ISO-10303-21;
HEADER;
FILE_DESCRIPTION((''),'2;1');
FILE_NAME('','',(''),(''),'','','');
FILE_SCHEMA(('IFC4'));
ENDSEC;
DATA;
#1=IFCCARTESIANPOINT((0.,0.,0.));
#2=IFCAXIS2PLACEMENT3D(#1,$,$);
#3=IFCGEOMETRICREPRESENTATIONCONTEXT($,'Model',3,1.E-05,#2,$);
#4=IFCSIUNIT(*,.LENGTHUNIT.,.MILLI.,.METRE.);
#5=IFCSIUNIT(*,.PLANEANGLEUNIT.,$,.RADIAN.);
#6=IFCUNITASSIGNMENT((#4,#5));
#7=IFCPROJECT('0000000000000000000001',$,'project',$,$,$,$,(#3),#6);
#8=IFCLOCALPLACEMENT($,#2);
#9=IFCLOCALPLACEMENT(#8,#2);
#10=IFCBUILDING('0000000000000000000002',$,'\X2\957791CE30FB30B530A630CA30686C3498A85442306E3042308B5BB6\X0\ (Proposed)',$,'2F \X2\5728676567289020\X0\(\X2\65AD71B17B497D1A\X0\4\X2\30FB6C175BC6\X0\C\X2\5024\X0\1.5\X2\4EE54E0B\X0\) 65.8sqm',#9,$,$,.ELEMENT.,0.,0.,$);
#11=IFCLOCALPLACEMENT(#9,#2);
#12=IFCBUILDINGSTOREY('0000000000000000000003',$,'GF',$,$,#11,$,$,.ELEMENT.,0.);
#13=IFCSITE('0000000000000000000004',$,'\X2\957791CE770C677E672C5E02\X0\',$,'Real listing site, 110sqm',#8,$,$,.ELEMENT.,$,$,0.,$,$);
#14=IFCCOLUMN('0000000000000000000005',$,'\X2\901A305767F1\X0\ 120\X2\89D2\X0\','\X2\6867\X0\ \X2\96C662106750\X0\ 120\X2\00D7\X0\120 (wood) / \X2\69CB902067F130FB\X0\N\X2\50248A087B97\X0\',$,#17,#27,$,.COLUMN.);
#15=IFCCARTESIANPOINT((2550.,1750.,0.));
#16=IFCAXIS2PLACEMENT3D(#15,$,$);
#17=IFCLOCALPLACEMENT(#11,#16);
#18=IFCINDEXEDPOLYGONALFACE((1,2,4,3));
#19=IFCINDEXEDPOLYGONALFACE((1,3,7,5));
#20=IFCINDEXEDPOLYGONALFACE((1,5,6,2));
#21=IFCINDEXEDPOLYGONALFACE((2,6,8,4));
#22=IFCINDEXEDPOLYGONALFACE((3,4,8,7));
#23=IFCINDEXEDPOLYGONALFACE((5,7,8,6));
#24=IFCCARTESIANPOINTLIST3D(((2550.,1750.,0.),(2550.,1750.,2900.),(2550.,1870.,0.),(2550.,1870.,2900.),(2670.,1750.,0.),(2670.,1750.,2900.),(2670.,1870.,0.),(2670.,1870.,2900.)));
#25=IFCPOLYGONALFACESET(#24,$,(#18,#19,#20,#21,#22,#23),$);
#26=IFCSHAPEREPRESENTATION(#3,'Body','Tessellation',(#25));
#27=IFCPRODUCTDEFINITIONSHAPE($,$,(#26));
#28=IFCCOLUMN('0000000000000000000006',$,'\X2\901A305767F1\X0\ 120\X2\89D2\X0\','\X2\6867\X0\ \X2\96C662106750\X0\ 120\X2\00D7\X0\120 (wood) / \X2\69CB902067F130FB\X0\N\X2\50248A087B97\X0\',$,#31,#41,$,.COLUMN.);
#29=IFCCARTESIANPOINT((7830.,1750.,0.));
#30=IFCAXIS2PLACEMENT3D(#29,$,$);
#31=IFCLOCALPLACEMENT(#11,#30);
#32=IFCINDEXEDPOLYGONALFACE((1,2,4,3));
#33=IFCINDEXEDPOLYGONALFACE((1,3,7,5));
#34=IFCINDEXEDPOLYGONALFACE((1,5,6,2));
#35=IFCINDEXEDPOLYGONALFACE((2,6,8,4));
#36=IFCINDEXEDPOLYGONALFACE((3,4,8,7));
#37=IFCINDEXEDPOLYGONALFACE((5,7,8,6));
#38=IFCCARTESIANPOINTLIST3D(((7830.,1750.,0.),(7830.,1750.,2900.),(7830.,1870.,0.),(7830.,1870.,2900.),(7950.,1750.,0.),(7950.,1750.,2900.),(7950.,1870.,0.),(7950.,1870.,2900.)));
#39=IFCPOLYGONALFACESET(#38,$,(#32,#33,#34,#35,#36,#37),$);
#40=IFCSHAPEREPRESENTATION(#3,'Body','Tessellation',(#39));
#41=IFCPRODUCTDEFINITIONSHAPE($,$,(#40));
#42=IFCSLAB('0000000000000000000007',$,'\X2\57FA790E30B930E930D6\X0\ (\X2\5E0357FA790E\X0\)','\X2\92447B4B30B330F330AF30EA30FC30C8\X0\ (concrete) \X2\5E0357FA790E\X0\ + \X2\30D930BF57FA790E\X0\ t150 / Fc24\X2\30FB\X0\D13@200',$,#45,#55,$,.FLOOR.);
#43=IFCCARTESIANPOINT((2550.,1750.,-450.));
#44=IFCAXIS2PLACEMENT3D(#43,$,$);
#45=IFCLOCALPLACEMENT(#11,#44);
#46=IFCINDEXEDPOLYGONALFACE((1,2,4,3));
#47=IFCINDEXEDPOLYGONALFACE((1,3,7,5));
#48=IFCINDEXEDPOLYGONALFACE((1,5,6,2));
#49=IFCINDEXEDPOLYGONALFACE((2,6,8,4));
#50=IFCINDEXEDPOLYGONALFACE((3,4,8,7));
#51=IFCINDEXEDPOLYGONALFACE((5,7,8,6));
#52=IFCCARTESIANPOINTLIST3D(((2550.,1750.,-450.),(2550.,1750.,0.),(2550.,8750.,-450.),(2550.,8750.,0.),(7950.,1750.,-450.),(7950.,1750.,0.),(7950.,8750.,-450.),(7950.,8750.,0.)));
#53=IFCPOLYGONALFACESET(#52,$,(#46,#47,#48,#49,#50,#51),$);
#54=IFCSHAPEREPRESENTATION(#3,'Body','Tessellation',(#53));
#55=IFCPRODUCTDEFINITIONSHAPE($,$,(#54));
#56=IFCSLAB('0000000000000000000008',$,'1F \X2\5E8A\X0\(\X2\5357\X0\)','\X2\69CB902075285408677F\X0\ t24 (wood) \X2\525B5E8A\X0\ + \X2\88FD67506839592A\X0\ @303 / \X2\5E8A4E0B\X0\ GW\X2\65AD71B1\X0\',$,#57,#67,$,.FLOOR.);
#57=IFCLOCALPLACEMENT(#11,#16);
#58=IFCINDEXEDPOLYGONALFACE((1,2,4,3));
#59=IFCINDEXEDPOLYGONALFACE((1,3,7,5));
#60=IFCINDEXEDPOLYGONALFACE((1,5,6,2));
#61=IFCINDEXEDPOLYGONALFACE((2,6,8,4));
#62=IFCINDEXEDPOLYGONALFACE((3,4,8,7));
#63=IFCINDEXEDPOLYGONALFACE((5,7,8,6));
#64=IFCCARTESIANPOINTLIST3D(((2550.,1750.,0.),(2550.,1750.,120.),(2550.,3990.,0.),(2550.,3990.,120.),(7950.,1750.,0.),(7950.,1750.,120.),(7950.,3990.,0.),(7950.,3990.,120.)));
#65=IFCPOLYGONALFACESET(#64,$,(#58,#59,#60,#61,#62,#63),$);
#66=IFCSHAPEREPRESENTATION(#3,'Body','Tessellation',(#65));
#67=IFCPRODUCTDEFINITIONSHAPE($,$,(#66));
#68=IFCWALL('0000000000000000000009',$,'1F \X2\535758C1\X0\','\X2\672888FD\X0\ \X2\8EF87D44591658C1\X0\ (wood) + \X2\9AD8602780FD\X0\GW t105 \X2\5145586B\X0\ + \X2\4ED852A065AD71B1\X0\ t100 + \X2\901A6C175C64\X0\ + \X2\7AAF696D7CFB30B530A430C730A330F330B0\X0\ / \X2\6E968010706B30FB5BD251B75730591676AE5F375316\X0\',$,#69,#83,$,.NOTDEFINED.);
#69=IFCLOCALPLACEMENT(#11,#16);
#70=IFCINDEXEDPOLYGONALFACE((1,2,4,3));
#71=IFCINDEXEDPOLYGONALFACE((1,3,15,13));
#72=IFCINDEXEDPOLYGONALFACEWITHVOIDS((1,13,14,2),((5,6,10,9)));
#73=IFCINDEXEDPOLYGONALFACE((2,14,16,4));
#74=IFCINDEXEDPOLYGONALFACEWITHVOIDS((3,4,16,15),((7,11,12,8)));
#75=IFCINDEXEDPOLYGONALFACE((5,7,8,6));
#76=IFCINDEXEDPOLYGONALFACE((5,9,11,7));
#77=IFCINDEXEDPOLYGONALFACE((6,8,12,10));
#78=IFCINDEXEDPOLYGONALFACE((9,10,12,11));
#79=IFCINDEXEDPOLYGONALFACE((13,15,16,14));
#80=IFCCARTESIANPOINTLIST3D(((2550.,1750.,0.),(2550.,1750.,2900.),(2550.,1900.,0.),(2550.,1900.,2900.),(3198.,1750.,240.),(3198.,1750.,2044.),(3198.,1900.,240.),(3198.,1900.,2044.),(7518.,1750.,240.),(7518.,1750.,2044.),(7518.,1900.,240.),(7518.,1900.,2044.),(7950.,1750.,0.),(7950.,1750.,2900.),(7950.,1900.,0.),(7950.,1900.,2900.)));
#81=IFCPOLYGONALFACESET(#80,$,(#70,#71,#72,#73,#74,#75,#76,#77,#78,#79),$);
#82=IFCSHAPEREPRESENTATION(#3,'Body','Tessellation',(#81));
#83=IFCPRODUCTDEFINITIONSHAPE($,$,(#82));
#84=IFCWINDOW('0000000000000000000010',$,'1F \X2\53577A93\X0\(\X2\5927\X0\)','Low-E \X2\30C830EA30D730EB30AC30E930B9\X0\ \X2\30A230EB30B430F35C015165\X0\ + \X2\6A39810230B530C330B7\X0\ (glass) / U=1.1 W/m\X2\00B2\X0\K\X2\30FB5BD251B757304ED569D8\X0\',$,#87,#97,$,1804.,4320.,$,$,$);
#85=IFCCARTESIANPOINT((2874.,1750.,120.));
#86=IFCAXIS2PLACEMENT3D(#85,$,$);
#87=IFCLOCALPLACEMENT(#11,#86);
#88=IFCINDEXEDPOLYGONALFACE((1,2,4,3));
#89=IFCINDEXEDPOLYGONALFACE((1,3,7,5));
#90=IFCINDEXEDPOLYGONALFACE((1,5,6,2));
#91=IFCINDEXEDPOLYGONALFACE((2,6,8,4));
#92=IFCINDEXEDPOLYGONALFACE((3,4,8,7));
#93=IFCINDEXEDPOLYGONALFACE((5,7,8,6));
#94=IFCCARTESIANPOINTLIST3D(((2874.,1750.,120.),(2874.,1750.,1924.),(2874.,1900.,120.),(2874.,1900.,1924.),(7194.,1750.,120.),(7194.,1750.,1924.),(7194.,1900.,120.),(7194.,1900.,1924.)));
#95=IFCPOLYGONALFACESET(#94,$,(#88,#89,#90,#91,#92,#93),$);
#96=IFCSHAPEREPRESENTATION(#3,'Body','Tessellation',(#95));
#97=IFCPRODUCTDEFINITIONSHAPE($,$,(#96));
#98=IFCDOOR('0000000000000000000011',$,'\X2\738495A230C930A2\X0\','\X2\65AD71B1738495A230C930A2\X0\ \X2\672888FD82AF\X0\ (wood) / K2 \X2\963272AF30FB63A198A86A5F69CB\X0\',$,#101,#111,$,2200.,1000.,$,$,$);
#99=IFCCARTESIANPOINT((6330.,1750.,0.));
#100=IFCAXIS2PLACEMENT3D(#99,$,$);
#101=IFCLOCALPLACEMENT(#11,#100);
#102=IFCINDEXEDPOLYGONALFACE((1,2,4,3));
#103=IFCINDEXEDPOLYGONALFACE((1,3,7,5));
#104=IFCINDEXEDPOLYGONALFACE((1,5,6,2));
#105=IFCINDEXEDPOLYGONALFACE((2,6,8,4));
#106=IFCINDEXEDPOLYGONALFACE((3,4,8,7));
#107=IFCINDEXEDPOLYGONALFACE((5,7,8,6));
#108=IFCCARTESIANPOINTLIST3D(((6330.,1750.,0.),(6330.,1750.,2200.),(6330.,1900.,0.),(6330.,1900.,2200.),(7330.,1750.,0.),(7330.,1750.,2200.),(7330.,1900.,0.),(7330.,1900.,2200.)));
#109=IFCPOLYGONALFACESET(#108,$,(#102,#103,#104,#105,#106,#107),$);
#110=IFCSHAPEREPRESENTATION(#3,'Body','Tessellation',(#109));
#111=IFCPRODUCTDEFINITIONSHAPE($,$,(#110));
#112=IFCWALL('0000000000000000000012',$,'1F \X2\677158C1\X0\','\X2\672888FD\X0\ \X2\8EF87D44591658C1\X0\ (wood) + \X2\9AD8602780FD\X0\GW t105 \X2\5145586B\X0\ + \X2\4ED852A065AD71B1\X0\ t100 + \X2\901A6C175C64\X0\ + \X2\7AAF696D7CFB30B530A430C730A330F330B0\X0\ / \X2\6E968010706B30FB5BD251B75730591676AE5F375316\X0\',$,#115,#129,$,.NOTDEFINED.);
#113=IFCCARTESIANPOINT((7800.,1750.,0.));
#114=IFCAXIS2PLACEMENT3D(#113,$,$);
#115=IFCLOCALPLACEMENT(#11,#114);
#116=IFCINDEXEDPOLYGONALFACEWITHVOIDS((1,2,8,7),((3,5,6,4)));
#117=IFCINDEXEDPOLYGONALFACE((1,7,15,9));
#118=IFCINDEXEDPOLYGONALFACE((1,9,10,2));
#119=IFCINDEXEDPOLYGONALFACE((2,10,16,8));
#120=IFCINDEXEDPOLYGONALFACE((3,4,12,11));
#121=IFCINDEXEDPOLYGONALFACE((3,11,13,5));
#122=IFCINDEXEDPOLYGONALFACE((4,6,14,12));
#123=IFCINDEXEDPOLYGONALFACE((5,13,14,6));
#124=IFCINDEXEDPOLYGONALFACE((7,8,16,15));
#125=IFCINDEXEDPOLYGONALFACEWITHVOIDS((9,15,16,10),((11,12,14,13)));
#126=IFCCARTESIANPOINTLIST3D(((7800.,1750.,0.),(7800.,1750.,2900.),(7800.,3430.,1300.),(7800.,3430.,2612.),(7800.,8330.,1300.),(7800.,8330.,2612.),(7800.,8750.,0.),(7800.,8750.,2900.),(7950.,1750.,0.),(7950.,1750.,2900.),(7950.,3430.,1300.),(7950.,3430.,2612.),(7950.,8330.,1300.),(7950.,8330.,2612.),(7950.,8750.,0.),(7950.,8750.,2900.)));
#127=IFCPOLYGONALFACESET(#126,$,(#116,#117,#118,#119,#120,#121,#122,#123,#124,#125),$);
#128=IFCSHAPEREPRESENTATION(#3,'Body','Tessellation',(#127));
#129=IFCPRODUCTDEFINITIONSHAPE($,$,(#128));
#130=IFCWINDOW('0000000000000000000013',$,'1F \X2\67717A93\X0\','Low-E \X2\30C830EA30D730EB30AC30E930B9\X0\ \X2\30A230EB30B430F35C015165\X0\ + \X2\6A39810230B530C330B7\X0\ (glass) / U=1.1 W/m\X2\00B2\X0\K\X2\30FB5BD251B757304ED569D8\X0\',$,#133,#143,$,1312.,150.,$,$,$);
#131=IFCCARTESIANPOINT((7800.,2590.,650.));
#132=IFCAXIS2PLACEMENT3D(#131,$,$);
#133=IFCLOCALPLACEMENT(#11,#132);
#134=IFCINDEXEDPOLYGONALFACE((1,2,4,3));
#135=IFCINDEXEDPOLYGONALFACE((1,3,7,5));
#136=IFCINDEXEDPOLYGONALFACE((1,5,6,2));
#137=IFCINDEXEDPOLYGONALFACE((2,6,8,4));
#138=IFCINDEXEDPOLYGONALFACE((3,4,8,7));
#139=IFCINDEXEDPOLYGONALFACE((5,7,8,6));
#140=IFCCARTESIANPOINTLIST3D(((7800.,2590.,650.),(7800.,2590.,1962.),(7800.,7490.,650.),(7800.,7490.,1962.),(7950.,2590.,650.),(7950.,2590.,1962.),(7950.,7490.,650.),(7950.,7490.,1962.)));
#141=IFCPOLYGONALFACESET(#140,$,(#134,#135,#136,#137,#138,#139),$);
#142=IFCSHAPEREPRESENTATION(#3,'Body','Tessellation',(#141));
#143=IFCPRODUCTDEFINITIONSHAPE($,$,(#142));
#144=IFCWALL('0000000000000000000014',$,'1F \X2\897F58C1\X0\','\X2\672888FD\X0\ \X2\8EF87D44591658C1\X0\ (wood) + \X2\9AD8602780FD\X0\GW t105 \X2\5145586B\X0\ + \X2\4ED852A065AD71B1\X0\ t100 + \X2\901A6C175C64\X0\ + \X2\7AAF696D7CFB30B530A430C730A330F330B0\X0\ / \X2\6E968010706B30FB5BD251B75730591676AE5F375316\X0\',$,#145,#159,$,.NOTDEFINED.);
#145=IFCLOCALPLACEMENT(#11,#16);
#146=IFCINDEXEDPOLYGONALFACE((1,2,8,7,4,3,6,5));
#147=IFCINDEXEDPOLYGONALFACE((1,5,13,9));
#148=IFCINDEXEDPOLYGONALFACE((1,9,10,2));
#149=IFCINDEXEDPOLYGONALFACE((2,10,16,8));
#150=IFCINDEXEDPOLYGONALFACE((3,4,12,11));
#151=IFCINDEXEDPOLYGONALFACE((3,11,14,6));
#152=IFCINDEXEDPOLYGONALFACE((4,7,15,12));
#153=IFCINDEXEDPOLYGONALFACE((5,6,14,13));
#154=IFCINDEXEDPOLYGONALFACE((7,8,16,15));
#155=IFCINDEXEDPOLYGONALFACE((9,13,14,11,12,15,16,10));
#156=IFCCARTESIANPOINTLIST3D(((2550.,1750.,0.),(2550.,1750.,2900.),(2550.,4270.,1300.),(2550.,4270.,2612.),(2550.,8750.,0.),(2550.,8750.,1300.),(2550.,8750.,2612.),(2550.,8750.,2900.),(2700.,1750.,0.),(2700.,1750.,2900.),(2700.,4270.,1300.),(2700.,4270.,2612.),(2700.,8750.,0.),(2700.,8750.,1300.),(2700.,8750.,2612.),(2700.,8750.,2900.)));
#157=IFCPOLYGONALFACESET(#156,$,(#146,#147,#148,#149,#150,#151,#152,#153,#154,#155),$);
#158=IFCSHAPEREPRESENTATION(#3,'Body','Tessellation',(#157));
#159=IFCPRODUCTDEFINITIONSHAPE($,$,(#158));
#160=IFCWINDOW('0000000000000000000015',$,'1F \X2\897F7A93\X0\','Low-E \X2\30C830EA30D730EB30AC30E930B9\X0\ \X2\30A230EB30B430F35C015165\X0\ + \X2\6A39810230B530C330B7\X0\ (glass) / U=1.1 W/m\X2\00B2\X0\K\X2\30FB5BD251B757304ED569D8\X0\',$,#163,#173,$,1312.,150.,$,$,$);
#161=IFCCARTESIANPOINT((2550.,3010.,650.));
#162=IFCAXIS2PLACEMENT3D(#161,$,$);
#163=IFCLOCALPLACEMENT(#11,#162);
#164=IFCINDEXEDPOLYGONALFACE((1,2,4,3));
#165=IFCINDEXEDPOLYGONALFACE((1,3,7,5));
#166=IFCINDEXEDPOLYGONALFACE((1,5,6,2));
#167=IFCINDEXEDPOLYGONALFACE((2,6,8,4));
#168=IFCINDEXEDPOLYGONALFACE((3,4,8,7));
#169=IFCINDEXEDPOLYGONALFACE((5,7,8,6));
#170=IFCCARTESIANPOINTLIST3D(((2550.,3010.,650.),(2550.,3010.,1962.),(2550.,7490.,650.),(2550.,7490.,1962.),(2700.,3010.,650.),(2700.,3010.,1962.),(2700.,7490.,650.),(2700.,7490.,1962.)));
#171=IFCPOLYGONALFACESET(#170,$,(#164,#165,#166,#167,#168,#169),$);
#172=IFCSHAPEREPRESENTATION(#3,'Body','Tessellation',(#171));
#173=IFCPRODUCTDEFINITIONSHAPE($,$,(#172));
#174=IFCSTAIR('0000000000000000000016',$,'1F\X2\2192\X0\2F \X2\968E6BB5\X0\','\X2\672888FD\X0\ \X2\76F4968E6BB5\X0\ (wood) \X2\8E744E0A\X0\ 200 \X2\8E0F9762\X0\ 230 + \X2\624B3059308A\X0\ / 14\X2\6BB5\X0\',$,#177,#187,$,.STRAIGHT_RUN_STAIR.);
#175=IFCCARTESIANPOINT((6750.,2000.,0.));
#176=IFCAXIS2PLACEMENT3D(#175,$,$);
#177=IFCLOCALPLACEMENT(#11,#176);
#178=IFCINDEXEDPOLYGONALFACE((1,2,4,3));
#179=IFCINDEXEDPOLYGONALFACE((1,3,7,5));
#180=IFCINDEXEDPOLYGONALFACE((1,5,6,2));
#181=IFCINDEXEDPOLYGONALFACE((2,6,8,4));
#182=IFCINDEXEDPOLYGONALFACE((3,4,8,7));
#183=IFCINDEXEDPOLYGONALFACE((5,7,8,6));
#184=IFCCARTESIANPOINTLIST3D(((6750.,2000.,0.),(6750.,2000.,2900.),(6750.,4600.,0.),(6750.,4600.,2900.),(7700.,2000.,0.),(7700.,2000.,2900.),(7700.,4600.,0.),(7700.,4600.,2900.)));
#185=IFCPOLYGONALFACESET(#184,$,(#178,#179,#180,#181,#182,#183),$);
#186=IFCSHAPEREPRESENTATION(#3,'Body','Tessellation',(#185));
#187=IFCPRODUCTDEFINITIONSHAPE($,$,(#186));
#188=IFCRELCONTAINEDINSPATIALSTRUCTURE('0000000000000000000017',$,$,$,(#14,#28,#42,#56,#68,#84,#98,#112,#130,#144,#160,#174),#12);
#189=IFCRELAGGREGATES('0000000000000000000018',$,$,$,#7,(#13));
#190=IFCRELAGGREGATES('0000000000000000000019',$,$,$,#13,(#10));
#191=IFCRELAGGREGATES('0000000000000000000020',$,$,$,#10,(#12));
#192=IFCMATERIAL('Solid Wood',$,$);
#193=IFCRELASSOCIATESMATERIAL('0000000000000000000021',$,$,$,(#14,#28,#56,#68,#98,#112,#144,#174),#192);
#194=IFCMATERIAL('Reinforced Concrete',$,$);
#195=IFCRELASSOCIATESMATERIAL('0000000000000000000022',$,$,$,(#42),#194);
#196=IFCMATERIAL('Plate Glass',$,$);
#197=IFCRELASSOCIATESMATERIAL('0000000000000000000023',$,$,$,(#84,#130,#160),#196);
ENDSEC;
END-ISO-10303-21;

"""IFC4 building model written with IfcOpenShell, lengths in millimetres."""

from ifc_helpers import new_model, si_unit, frame, frame_2d, origin, place, context, project, spatial, rectangle, extrude, material, element, fill, save


model = new_model("IFC4")

# Units and contexts
model_context = context("Model", 3, precision=1e-05, world=origin())
ifc_project = project(units=[si_unit("LENGTHUNIT", "METRE", prefix="MILLI"), si_unit("PLANEANGLEUNIT", "RADIAN")], contexts=[model_context])

# Site, building, storey
site_placement = place(None, origin())
site = spatial("IfcSite", under=ifc_project, at=site_placement, Name="長野県松本市", ObjectType="Real listing site, 110sqm", CompositionType="ELEMENT", RefElevation=0.0)
building_placement = place(site_placement, origin())
building = spatial("IfcBuilding", under=site, at=building_placement, Name="長野・サウナと水風呂のある家 (Proposed)", ObjectType="2F 在来木造(断熱等級4・気密C値1.5以下) 65.8sqm", CompositionType="ELEMENT", ElevationOfRefHeight=0.0, ElevationOfTerrain=0.0)
storey_placement = place(building_placement, origin())
storey = spatial("IfcBuildingStorey", under=building, at=storey_placement, Name="GF", CompositionType="ELEMENT", Elevation=0.0)

# Columns
ifc_material_1 = material(Name="Solid Wood")
column_1_placement = place(storey_placement, frame((2550.0, 1750.0, 0.0)))
element("IfcColumn", 1, at=column_1_placement, inside=storey, material=ifc_material_1, Name="通し柱 120角", Description="桧 集成材 120×120 (wood) / 構造柱・N値計算", PredefinedType="COLUMN", context=model_context, shape_type="SweptSolid", body=[
    extrude(rectangle(XDim=120.0, YDim=120.0, at=frame_2d((60.0, 60.0))), frame((2550.0, 1750.0, 0.0)), (0.0, 0.0, 1.0), 2900.0),
])
column_2_placement = place(storey_placement, frame((7830.0, 1750.0, 0.0)))
element("IfcColumn", 2, at=column_2_placement, inside=storey, material=ifc_material_1, Name="通し柱 120角", Description="桧 集成材 120×120 (wood) / 構造柱・N値計算", PredefinedType="COLUMN", context=model_context, shape_type="SweptSolid", body=[
    extrude(rectangle(XDim=120.0, YDim=120.0, at=frame_2d((60.0, 60.0))), frame((7830.0, 1750.0, 0.0)), (0.0, 0.0, 1.0), 2900.0),
])

# Slabs
ifc_material_2 = material(Name="Reinforced Concrete")
slab_1_placement = place(storey_placement, frame((2550.0, 1750.0, -450.0)))
element("IfcSlab", 3, at=slab_1_placement, inside=storey, material=ifc_material_2, Name="基礎スラブ (布基礎)", Description="鉄筋コンクリート (concrete) 布基礎 + ベタ基礎 t150 / Fc24・D13@200", PredefinedType="FLOOR", context=model_context, shape_type="SweptSolid", body=[
    extrude(rectangle(XDim=5400.0, YDim=7000.0, at=frame_2d((2700.0, 3500.0))), frame((2550.0, 1750.0, -450.0)), (0.0, 0.0, 1.0), 450.0),
])
slab_2_placement = place(storey_placement, frame((2550.0, 1750.0, 0.0)))
element("IfcSlab", 4, at=slab_2_placement, inside=storey, material=ifc_material_1, Name="1F 床(南)", Description="構造用合板 t24 (wood) 剛床 + 製材根太 @303 / 床下 GW断熱", PredefinedType="FLOOR", context=model_context, shape_type="SweptSolid", body=[
    extrude(rectangle(XDim=5400.0, YDim=2240.0, at=frame_2d((2700.0, 1120.0))), frame((2550.0, 1750.0, 0.0)), (0.0, 0.0, 1.0), 120.0),
])

# Wall, openings, window, door
wall_1_placement = place(storey_placement, frame((2550.0, 1750.0, 0.0)))
wall_1 = element("IfcWall", 5, at=wall_1_placement, inside=storey, material=ifc_material_1, Name="1F 南壁", Description="木製 軸組外壁 (wood) + 高性能GW t105 充填 + 付加断熱 t100 + 通気層 + 窯業系サイディング / 準耐火・寒冷地外皮強化", PredefinedType="NOTDEFINED", context=model_context, shape_type="SweptSolid", body=[
    extrude(rectangle(XDim=5400.0, YDim=150.0, at=frame_2d((2700.0, 75.0))), frame((2550.0, 1750.0, 0.0)), (0.0, 0.0, 1.0), 2900.0),
])
opening_1_placement = place(storey_placement, frame((2874.0, 1750.0, 120.0)))
opening_1 = element("IfcOpeningElement", 6, at=opening_1_placement, cuts=wall_1, PredefinedType="NOTDEFINED", context=model_context, shape_type="SweptSolid", body=[
    extrude(rectangle(XDim=4320.0, YDim=150.0, at=frame_2d((2160.0, 75.0))), frame((2874.0, 1750.0, 120.0)), (0.0, 0.0, 1.0), 1804.0),
])
opening_2_placement = place(storey_placement, frame((6330.0, 1750.0, 0.0)))
opening_2 = element("IfcOpeningElement", 7, at=opening_2_placement, cuts=wall_1, PredefinedType="NOTDEFINED", context=model_context, shape_type="SweptSolid", body=[
    extrude(rectangle(XDim=1000.0, YDim=150.0, at=frame_2d((500.0, 75.0))), frame((6330.0, 1750.0, 0.0)), (0.0, 0.0, 1.0), 2200.0),
])
ifc_material_3 = material(Name="Plate Glass")
window_1_placement = place(storey_placement, frame((2874.0, 1750.0, 120.0)))
window_1 = element("IfcWindow", 8, at=window_1_placement, inside=storey, material=ifc_material_3, Name="1F 南窓(大)", Description="Low-E トリプルガラス アルゴン封入 + 樹脂サッシ (glass) / U=1.1 W/m²K・寒冷地仕様", OverallHeight=1804.0, OverallWidth=4320.0, context=model_context, shape_type="SweptSolid", body=[
    extrude(rectangle(XDim=4320.0, YDim=150.0, at=frame_2d((2160.0, 75.0))), frame((2874.0, 1750.0, 120.0)), (0.0, 0.0, 1.0), 1804.0),
])
fill(opening_1, window_1)
door_placement = place(storey_placement, frame((6330.0, 1750.0, 0.0)))
door = element("IfcDoor", 9, at=door_placement, inside=storey, material=ifc_material_1, Name="玄関ドア", Description="断熱玄関ドア 木製芯 (wood) / K2 防犯・採風機構", OverallHeight=2200.0, OverallWidth=1000.0, context=model_context, shape_type="SweptSolid", body=[
    extrude(rectangle(XDim=1000.0, YDim=150.0, at=frame_2d((500.0, 75.0))), frame((6330.0, 1750.0, 0.0)), (0.0, 0.0, 1.0), 2200.0),
])
fill(opening_2, door)

# Walls, openings, windows
wall_2_placement = place(storey_placement, frame((7800.0, 1750.0, 0.0)))
wall_2 = element("IfcWall", 10, at=wall_2_placement, inside=storey, material=ifc_material_1, Name="1F 東壁", Description="木製 軸組外壁 (wood) + 高性能GW t105 充填 + 付加断熱 t100 + 通気層 + 窯業系サイディング / 準耐火・寒冷地外皮強化", PredefinedType="NOTDEFINED", context=model_context, shape_type="SweptSolid", body=[
    extrude(rectangle(XDim=150.0, YDim=7000.0, at=frame_2d((75.0, 3500.0))), frame((7800.0, 1750.0, 0.0)), (0.0, 0.0, 1.0), 2900.0),
])
opening_3_placement = place(storey_placement, frame((7800.0, 2590.0, 650.0)))
opening_3 = element("IfcOpeningElement", 11, at=opening_3_placement, cuts=wall_2, PredefinedType="NOTDEFINED", context=model_context, shape_type="SweptSolid", body=[
    extrude(rectangle(XDim=150.0, YDim=4900.0, at=frame_2d((75.0, 2450.0))), frame((7800.0, 2590.0, 650.0)), (0.0, 0.0, 1.0), 1312.0),
])
window_2_placement = place(storey_placement, frame((7800.0, 2590.0, 650.0)))
window_2 = element("IfcWindow", 12, at=window_2_placement, inside=storey, material=ifc_material_3, Name="1F 東窓", Description="Low-E トリプルガラス アルゴン封入 + 樹脂サッシ (glass) / U=1.1 W/m²K・寒冷地仕様", OverallHeight=1312.0, OverallWidth=150.0, context=model_context, shape_type="SweptSolid", body=[
    extrude(rectangle(XDim=150.0, YDim=4900.0, at=frame_2d((75.0, 2450.0))), frame((7800.0, 2590.0, 650.0)), (0.0, 0.0, 1.0), 1312.0),
])
fill(opening_3, window_2)
wall_3_placement = place(storey_placement, frame((2550.0, 1750.0, 0.0)))
wall_3 = element("IfcWall", 13, at=wall_3_placement, inside=storey, material=ifc_material_1, Name="1F 西壁", Description="木製 軸組外壁 (wood) + 高性能GW t105 充填 + 付加断熱 t100 + 通気層 + 窯業系サイディング / 準耐火・寒冷地外皮強化", PredefinedType="NOTDEFINED", context=model_context, shape_type="SweptSolid", body=[
    extrude(rectangle(XDim=150.0, YDim=7000.0, at=frame_2d((75.0, 3500.0))), frame((2550.0, 1750.0, 0.0)), (0.0, 0.0, 1.0), 2900.0),
])
opening_4_placement = place(storey_placement, frame((2550.0, 3010.0, 650.0)))
opening_4 = element("IfcOpeningElement", 14, at=opening_4_placement, cuts=wall_3, PredefinedType="NOTDEFINED", context=model_context, shape_type="SweptSolid", body=[
    extrude(rectangle(XDim=150.0, YDim=4480.0, at=frame_2d((75.0, 2240.0))), frame((2550.0, 3010.0, 650.0)), (0.0, 0.0, 1.0), 1312.0),
])
window_3_placement = place(storey_placement, frame((2550.0, 3010.0, 650.0)))
window_3 = element("IfcWindow", 15, at=window_3_placement, inside=storey, material=ifc_material_3, Name="1F 西窓", Description="Low-E トリプルガラス アルゴン封入 + 樹脂サッシ (glass) / U=1.1 W/m²K・寒冷地仕様", OverallHeight=1312.0, OverallWidth=150.0, context=model_context, shape_type="SweptSolid", body=[
    extrude(rectangle(XDim=150.0, YDim=4480.0, at=frame_2d((75.0, 2240.0))), frame((2550.0, 3010.0, 650.0)), (0.0, 0.0, 1.0), 1312.0),
])
fill(opening_4, window_3)

# Stair
stair_placement = place(storey_placement, frame((6750.0, 2000.0, 0.0)))
element("IfcStair", 16, at=stair_placement, inside=storey, material=ifc_material_1, Name="1F→2F 階段", Description="木製 直階段 (wood) 蹴上 200 踏面 230 + 手すり / 14段", PredefinedType="STRAIGHT_RUN_STAIR", context=model_context, shape_type="SweptSolid", body=[
    extrude(rectangle(XDim=950.0, YDim=2600.0, at=frame_2d((475.0, 1300.0))), frame((6750.0, 2000.0, 0.0)), (0.0, 0.0, 1.0), 2900.0),
])

save(model, "model.ifc")
